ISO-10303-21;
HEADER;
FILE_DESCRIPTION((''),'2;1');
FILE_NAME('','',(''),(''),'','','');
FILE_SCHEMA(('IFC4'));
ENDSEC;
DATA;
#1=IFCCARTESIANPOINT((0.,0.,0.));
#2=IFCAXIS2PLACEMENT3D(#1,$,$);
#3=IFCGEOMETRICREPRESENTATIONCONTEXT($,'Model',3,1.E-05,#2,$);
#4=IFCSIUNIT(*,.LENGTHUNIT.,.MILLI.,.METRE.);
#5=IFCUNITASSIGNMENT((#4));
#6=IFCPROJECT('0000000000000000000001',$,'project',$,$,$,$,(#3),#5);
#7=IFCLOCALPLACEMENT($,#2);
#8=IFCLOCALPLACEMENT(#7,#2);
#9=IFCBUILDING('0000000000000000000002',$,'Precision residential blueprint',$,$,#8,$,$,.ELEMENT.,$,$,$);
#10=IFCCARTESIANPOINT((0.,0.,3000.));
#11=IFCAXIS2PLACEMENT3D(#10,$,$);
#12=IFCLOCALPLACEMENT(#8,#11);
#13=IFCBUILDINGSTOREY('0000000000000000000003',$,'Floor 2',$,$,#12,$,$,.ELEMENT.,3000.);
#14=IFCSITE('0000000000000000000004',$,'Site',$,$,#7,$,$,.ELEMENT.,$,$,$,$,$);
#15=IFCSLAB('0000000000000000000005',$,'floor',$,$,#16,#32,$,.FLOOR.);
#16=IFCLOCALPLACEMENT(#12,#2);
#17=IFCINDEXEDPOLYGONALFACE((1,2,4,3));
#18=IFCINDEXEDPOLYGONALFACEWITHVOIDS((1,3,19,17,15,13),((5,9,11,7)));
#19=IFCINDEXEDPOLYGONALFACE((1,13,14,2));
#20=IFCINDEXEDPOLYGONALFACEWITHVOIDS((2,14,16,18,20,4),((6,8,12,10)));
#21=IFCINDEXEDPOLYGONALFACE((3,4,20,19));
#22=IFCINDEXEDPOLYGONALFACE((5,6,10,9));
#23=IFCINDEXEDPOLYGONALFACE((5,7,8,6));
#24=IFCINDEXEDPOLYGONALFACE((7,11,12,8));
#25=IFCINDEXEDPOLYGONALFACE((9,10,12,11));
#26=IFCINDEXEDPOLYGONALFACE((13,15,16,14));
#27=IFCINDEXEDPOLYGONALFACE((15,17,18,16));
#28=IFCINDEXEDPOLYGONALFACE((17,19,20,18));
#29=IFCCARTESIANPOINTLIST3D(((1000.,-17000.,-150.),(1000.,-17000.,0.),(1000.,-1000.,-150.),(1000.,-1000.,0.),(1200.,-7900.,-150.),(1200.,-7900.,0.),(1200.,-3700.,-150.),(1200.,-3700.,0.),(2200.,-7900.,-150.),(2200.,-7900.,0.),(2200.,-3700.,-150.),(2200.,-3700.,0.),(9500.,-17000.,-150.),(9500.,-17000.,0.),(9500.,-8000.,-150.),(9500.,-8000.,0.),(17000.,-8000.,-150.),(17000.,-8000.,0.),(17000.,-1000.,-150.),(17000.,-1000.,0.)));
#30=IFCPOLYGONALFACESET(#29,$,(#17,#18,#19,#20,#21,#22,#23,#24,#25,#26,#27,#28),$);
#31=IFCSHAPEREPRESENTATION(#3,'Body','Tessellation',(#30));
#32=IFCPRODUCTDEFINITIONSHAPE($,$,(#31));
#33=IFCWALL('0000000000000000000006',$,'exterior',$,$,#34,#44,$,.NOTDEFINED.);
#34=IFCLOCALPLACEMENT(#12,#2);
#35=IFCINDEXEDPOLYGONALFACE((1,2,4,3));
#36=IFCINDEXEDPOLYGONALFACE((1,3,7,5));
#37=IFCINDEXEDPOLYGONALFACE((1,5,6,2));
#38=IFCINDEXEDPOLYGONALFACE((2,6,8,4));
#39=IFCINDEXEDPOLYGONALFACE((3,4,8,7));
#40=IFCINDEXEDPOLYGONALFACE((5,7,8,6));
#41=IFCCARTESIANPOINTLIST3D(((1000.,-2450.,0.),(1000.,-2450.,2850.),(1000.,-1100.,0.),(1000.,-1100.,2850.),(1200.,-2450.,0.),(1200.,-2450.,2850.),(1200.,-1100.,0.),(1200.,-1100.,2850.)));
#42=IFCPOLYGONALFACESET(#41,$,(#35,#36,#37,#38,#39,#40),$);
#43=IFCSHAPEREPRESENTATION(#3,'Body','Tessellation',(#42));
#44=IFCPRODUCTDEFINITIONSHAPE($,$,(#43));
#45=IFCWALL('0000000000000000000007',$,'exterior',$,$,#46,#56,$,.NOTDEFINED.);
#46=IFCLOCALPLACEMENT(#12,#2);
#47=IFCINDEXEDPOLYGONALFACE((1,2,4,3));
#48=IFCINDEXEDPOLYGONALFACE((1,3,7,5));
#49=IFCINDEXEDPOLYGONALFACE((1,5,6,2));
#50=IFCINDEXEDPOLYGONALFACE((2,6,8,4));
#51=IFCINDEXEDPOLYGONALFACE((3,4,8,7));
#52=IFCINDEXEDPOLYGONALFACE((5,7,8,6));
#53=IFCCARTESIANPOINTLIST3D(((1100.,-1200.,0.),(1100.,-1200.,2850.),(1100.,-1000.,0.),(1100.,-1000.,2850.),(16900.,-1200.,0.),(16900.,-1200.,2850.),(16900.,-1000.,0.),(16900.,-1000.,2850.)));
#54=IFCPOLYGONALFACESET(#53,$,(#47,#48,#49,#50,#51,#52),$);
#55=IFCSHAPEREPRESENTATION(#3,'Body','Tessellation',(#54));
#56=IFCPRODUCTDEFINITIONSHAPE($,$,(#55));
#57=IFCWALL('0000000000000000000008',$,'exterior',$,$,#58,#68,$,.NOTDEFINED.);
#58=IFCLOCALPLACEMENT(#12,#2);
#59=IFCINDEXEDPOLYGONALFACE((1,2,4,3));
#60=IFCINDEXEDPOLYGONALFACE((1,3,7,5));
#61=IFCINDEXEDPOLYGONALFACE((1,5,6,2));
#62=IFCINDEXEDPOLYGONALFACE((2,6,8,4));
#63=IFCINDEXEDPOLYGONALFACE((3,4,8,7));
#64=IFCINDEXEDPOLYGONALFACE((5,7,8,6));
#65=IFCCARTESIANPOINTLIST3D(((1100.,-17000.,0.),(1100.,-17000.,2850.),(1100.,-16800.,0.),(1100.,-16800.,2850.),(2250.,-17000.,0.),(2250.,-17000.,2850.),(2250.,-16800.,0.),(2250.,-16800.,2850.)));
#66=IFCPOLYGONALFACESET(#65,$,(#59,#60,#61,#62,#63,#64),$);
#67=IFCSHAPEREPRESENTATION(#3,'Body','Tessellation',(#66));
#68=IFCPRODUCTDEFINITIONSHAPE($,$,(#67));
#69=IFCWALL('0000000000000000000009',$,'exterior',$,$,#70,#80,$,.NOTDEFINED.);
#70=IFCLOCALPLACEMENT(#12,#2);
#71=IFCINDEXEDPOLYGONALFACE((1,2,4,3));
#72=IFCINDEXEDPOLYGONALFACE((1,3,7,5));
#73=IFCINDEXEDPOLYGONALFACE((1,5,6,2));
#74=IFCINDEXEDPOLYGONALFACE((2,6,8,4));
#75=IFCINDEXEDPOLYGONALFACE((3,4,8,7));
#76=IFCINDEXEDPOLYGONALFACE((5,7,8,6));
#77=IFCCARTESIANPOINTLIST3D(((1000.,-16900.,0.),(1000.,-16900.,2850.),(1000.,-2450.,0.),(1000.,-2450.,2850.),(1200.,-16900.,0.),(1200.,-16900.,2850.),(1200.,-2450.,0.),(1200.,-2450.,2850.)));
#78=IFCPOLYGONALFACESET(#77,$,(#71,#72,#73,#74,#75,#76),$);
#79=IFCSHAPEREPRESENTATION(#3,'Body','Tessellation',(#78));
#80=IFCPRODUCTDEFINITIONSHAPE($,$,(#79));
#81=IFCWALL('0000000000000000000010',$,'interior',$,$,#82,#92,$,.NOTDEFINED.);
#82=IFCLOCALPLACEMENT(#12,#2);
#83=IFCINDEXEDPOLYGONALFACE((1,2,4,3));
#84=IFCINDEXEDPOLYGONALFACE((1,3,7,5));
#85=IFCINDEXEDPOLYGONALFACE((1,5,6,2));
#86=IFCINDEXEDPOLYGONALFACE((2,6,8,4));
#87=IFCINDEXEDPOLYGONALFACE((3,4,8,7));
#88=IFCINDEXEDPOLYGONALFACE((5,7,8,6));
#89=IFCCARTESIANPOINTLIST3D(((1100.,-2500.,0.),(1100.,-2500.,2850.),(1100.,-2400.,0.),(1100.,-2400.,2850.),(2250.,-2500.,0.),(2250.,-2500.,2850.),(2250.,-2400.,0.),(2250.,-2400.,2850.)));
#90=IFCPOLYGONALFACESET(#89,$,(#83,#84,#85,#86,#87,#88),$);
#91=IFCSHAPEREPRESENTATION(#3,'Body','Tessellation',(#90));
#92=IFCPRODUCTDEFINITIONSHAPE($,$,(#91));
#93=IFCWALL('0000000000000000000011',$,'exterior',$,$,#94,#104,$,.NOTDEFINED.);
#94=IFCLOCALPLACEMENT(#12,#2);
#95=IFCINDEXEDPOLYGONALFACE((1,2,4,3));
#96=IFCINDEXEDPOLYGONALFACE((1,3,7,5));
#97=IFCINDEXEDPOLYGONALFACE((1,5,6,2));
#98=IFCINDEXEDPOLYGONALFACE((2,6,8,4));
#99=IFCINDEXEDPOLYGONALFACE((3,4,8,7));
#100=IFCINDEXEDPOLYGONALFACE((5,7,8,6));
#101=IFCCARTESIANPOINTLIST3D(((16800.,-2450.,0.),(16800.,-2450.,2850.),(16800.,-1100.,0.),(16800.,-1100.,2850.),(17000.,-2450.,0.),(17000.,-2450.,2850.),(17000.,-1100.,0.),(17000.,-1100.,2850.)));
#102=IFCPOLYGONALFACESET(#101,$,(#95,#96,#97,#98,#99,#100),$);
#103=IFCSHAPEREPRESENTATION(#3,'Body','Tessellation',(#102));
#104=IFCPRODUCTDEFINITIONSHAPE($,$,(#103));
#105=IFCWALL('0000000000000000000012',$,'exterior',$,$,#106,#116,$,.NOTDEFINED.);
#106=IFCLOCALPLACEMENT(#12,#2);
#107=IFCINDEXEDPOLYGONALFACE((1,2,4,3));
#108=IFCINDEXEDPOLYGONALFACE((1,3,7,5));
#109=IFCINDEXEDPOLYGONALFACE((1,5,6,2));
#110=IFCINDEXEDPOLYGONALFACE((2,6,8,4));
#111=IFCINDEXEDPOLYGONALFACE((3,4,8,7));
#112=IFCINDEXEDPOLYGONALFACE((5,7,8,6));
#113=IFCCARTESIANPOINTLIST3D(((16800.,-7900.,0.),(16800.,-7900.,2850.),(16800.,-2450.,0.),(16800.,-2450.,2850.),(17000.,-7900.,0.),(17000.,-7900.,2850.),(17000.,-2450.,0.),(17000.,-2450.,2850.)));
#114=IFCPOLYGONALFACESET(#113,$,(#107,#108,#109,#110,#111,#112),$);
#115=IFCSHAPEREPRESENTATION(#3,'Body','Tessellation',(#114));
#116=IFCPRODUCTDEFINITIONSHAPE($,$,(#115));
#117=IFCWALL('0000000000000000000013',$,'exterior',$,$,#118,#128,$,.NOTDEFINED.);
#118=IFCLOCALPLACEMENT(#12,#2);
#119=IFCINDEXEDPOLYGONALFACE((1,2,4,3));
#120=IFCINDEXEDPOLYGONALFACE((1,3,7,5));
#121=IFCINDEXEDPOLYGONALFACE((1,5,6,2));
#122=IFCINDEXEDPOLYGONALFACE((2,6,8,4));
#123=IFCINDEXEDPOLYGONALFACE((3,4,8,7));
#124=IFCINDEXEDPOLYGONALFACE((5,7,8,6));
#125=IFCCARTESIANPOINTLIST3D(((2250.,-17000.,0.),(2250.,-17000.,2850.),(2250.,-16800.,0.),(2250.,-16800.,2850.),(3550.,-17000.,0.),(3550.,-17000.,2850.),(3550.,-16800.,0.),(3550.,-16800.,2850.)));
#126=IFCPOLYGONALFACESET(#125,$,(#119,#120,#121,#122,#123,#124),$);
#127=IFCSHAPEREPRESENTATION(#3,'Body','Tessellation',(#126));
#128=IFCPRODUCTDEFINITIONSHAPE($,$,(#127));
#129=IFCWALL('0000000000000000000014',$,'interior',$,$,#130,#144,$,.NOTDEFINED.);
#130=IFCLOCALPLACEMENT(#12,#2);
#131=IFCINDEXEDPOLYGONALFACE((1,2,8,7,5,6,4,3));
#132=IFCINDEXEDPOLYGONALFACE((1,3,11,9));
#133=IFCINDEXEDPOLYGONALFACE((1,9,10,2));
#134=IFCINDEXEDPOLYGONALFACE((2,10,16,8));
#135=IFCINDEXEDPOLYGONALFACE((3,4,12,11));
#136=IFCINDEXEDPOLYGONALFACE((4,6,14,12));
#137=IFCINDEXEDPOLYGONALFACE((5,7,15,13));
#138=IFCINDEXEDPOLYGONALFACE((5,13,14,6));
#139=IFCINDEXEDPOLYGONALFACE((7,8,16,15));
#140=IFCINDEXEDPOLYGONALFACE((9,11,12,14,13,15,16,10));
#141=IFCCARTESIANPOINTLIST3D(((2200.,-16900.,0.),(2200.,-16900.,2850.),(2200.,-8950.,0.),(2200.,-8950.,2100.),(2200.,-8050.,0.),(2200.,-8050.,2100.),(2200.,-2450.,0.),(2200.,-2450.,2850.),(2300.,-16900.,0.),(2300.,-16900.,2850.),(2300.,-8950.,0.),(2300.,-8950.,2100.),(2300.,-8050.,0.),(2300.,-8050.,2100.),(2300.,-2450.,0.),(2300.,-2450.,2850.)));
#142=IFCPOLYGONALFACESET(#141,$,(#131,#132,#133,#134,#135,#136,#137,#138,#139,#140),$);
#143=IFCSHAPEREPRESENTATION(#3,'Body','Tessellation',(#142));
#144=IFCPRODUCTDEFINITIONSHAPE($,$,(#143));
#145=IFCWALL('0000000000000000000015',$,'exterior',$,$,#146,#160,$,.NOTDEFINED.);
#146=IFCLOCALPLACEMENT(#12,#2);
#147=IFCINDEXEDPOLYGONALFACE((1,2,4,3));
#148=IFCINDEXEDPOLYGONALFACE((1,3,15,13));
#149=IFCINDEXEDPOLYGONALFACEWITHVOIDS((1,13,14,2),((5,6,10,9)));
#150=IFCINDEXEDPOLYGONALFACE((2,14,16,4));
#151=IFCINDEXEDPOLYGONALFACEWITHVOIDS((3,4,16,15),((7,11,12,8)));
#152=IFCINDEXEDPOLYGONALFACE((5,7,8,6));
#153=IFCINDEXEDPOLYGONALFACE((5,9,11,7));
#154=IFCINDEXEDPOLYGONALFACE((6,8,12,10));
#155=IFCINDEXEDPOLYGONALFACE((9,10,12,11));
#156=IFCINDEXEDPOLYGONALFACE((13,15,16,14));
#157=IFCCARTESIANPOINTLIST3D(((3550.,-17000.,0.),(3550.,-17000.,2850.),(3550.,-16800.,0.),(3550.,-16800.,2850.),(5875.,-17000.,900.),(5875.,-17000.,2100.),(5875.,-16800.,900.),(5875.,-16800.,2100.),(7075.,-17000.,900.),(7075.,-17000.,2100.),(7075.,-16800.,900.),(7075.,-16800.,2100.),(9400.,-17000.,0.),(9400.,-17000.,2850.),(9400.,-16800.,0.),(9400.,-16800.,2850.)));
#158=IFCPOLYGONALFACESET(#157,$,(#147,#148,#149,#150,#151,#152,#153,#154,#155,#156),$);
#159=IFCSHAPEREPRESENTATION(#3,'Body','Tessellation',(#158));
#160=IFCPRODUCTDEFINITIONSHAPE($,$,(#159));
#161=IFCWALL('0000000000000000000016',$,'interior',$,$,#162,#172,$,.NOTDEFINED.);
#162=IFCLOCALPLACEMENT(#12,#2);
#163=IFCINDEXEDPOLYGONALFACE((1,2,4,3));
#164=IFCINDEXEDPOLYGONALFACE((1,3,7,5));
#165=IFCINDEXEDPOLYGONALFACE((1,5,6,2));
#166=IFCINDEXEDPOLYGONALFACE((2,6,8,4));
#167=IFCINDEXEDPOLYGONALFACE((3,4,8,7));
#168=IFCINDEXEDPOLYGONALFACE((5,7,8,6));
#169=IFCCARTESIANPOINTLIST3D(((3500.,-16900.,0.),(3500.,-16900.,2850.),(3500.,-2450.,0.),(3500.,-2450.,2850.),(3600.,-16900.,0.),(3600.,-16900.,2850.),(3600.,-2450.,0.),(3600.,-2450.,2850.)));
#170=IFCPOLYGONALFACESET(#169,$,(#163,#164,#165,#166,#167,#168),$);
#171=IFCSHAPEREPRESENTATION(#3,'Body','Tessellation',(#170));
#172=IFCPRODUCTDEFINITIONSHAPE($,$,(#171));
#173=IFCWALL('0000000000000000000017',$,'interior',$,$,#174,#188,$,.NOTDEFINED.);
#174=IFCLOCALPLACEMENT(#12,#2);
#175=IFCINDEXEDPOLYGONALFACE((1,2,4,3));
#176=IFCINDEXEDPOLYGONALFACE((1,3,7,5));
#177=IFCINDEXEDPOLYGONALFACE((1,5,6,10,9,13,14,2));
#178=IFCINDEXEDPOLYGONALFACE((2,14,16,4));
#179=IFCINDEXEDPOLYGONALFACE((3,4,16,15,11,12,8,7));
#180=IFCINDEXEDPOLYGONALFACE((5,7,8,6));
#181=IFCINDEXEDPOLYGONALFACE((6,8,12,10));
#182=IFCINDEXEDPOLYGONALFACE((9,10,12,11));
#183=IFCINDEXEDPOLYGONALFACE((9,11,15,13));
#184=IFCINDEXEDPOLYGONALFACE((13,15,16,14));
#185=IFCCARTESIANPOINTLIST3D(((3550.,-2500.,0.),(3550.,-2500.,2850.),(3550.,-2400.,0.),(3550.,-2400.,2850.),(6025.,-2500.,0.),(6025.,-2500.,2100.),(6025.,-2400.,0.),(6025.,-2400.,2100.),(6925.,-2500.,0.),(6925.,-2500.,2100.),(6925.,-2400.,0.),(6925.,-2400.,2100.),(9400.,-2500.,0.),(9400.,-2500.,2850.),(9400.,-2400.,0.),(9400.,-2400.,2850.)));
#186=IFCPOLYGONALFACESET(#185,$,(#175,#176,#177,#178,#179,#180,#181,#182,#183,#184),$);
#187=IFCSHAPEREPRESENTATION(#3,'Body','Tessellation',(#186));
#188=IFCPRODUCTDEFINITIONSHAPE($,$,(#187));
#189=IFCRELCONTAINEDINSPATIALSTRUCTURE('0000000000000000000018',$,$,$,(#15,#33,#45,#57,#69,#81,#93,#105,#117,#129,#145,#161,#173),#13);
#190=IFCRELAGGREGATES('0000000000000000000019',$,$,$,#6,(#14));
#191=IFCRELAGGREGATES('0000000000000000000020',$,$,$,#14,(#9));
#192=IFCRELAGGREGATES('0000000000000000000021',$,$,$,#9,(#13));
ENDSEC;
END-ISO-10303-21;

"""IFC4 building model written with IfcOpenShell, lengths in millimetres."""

from ifc_helpers import new_model, si_unit, frame, origin, place, context, project, spatial, polyline, outline, extrude, element, save


model = new_model("IFC4")

# Units and contexts
model_context = context("Model", 3, precision=1e-05, world=origin())
ifc_project = project(units=[si_unit("LENGTHUNIT", "METRE", prefix="MILLI")], contexts=[model_context])

# Site, building, storey
site_placement = place(None, origin())
site = spatial("IfcSite", under=ifc_project, at=site_placement, Name="Site", CompositionType="ELEMENT")
building_placement = place(site_placement, origin())
building = spatial("IfcBuilding", under=site, at=building_placement, Name="Precision residential blueprint", CompositionType="ELEMENT")
storey_placement = place(building_placement, frame((0.0, 0.0, 3000.0)))
storey = spatial("IfcBuildingStorey", under=building, at=storey_placement, Name="Floor 2", CompositionType="ELEMENT", Elevation=3000.0)

# Slab, opening
slab_placement = place(storey_placement, origin())
slab = element("IfcSlab", 1, at=slab_placement, inside=storey, Name="floor", PredefinedType="FLOOR", context=model_context, shape_type="SweptSolid", body=[
    extrude(outline(polyline([(1000.0, -17000.0), (9500.0, -17000.0), (9500.0, -8000.0), (17000.0, -8000.0), (17000.0, -1000.0), (1000.0, -1000.0), (1000.0, -17000.0)])), frame((0.0, 0.0, -150.0)), (0.0, 0.0, 1.0), 150.0),
])
opening_1_placement = place(storey_placement, origin())
element("IfcOpeningElement", 2, at=opening_1_placement, cuts=slab, PredefinedType="OPENING", context=model_context, shape_type="SweptSolid", body=[
    extrude(outline(polyline([(1200.0, -7900.0), (2200.0, -7900.0), (2200.0, -3700.0), (1200.0, -3700.0), (1200.0, -7900.0)])), frame((0.0, 0.0, -150.0)), (0.0, 0.0, 1.0), 150.0),
])

# Walls
wall_1_placement = place(storey_placement, origin())
element("IfcWall", 3, at=wall_1_placement, inside=storey, Name="exterior", PredefinedType="NOTDEFINED", context=model_context, shape_type="SweptSolid", body=[
    extrude(outline(polyline([(1200.0, -1100.0), (1200.0, -2450.0), (1000.0, -2450.0), (1000.0, -1100.0), (1200.0, -1100.0)])), origin(), (0.0, 0.0, 1.0), 2850.0),
])
wall_2_placement = place(storey_placement, origin())
element("IfcWall", 4, at=wall_2_placement, inside=storey, Name="exterior", PredefinedType="NOTDEFINED", context=model_context, shape_type="SweptSolid", body=[
    extrude(outline(polyline([(1100.0, -1000.0), (16900.0, -1000.0), (16900.0, -1200.0), (1100.0, -1200.0), (1100.0, -1000.0)])), origin(), (0.0, 0.0, 1.0), 2850.0),
])
wall_3_placement = place(storey_placement, origin())
element("IfcWall", 5, at=wall_3_placement, inside=storey, Name="exterior", PredefinedType="NOTDEFINED", context=model_context, shape_type="SweptSolid", body=[
    extrude(outline(polyline([(1100.0, -16800.0), (2250.0, -16800.0), (2250.0, -17000.0), (1100.0, -17000.0), (1100.0, -16800.0)])), origin(), (0.0, 0.0, 1.0), 2850.0),
])
wall_4_placement = place(storey_placement, origin())
element("IfcWall", 6, at=wall_4_placement, inside=storey, Name="exterior", PredefinedType="NOTDEFINED", context=model_context, shape_type="SweptSolid", body=[
    extrude(outline(polyline([(1200.0, -2450.0), (1200.0, -16900.0), (1000.0, -16900.0), (1000.0, -2450.0), (1200.0, -2450.0)])), origin(), (0.0, 0.0, 1.0), 2850.0),
])
wall_5_placement = place(storey_placement, origin())
element("IfcWall", 7, at=wall_5_placement, inside=storey, Name="interior", PredefinedType="NOTDEFINED", context=model_context, shape_type="SweptSolid", body=[
    extrude(outline(polyline([(1100.0, -2400.0), (2250.0, -2400.0), (2250.0, -2500.0), (1100.0, -2500.0), (1100.0, -2400.0)])), origin(), (0.0, 0.0, 1.0), 2850.0),
])
wall_6_placement = place(storey_placement, origin())
element("IfcWall", 8, at=wall_6_placement, inside=storey, Name="exterior", PredefinedType="NOTDEFINED", context=model_context, shape_type="SweptSolid", body=[
    extrude(outline(polyline([(17000.0, -1100.0), (17000.0, -2450.0), (16800.0, -2450.0), (16800.0, -1100.0), (17000.0, -1100.0)])), origin(), (0.0, 0.0, 1.0), 2850.0),
])
wall_7_placement = place(storey_placement, origin())
element("IfcWall", 9, at=wall_7_placement, inside=storey, Name="exterior", PredefinedType="NOTDEFINED", context=model_context, shape_type="SweptSolid", body=[
    extrude(outline(polyline([(17000.0, -2450.0), (17000.0, -7900.0), (16800.0, -7900.0), (16800.0, -2450.0), (17000.0, -2450.0)])), origin(), (0.0, 0.0, 1.0), 2850.0),
])
wall_8_placement = place(storey_placement, origin())
element("IfcWall", 10, at=wall_8_placement, inside=storey, Name="exterior", PredefinedType="NOTDEFINED", context=model_context, shape_type="SweptSolid", body=[
    extrude(outline(polyline([(2250.0, -16800.0), (3550.0, -16800.0), (3550.0, -17000.0), (2250.0, -17000.0), (2250.0, -16800.0)])), origin(), (0.0, 0.0, 1.0), 2850.0),
])

# Walls, openings
wall_9_placement = place(storey_placement, origin())
wall_9 = element("IfcWall", 11, at=wall_9_placement, inside=storey, Name="interior", PredefinedType="NOTDEFINED", context=model_context, shape_type="SweptSolid", body=[
    extrude(outline(polyline([(2300.0, -2450.0), (2300.0, -16900.0), (2200.0, -16900.0), (2200.0, -2450.0), (2300.0, -2450.0)])), origin(), (0.0, 0.0, 1.0), 2850.0),
])
opening_2_placement = place(storey_placement, origin())
element("IfcOpeningElement", 12, at=opening_2_placement, cuts=wall_9, PredefinedType="OPENING", context=model_context, shape_type="SweptSolid", body=[
    extrude(outline(polyline([(2300.0, -8050.0), (2300.0, -8950.0), (2200.0, -8950.0), (2200.0, -8050.0), (2300.0, -8050.0)])), origin(), (0.0, 0.0, 1.0), 2100.0),
])
wall_10_placement = place(storey_placement, origin())
wall_10 = element("IfcWall", 13, at=wall_10_placement, inside=storey, Name="exterior", PredefinedType="NOTDEFINED", context=model_context, shape_type="SweptSolid", body=[
    extrude(outline(polyline([(3550.0, -16800.0), (9400.0, -16800.0), (9400.0, -17000.0), (3550.0, -17000.0), (3550.0, -16800.0)])), origin(), (0.0, 0.0, 1.0), 2850.0),
])
opening_3_placement = place(storey_placement, origin())
element("IfcOpeningElement", 14, at=opening_3_placement, cuts=wall_10, PredefinedType="OPENING", context=model_context, shape_type="SweptSolid", body=[
    extrude(outline(polyline([(5875.0, -16800.0), (7075.0, -16800.0), (7075.0, -17000.0), (5875.0, -17000.0), (5875.0, -16800.0)])), frame((0.0, 0.0, 900.0)), (0.0, 0.0, 1.0), 1200.0),
])

# Wall
wall_11_placement = place(storey_placement, origin())
element("IfcWall", 15, at=wall_11_placement, inside=storey, Name="interior", PredefinedType="NOTDEFINED", context=model_context, shape_type="SweptSolid", body=[
    extrude(outline(polyline([(3600.0, -2450.0), (3600.0, -16900.0), (3500.0, -16900.0), (3500.0, -2450.0), (3600.0, -2450.0)])), origin(), (0.0, 0.0, 1.0), 2850.0),
])

# Wall, opening
wall_12_placement = place(storey_placement, origin())
wall_12 = element("IfcWall", 16, at=wall_12_placement, inside=storey, Name="interior", PredefinedType="NOTDEFINED", context=model_context, shape_type="SweptSolid", body=[
    extrude(outline(polyline([(3550.0, -2400.0), (9400.0, -2400.0), (9400.0, -2500.0), (3550.0, -2500.0), (3550.0, -2400.0)])), origin(), (0.0, 0.0, 1.0), 2850.0),
])
opening_4_placement = place(storey_placement, origin())
element("IfcOpeningElement", 17, at=opening_4_placement, cuts=wall_12, PredefinedType="OPENING", context=model_context, shape_type="SweptSolid", body=[
    extrude(outline(polyline([(6025.0, -2400.0), (6925.0, -2400.0), (6925.0, -2500.0), (6025.0, -2500.0), (6025.0, -2400.0)])), origin(), (0.0, 0.0, 1.0), 2100.0),
])

save(model, "model.ifc")
